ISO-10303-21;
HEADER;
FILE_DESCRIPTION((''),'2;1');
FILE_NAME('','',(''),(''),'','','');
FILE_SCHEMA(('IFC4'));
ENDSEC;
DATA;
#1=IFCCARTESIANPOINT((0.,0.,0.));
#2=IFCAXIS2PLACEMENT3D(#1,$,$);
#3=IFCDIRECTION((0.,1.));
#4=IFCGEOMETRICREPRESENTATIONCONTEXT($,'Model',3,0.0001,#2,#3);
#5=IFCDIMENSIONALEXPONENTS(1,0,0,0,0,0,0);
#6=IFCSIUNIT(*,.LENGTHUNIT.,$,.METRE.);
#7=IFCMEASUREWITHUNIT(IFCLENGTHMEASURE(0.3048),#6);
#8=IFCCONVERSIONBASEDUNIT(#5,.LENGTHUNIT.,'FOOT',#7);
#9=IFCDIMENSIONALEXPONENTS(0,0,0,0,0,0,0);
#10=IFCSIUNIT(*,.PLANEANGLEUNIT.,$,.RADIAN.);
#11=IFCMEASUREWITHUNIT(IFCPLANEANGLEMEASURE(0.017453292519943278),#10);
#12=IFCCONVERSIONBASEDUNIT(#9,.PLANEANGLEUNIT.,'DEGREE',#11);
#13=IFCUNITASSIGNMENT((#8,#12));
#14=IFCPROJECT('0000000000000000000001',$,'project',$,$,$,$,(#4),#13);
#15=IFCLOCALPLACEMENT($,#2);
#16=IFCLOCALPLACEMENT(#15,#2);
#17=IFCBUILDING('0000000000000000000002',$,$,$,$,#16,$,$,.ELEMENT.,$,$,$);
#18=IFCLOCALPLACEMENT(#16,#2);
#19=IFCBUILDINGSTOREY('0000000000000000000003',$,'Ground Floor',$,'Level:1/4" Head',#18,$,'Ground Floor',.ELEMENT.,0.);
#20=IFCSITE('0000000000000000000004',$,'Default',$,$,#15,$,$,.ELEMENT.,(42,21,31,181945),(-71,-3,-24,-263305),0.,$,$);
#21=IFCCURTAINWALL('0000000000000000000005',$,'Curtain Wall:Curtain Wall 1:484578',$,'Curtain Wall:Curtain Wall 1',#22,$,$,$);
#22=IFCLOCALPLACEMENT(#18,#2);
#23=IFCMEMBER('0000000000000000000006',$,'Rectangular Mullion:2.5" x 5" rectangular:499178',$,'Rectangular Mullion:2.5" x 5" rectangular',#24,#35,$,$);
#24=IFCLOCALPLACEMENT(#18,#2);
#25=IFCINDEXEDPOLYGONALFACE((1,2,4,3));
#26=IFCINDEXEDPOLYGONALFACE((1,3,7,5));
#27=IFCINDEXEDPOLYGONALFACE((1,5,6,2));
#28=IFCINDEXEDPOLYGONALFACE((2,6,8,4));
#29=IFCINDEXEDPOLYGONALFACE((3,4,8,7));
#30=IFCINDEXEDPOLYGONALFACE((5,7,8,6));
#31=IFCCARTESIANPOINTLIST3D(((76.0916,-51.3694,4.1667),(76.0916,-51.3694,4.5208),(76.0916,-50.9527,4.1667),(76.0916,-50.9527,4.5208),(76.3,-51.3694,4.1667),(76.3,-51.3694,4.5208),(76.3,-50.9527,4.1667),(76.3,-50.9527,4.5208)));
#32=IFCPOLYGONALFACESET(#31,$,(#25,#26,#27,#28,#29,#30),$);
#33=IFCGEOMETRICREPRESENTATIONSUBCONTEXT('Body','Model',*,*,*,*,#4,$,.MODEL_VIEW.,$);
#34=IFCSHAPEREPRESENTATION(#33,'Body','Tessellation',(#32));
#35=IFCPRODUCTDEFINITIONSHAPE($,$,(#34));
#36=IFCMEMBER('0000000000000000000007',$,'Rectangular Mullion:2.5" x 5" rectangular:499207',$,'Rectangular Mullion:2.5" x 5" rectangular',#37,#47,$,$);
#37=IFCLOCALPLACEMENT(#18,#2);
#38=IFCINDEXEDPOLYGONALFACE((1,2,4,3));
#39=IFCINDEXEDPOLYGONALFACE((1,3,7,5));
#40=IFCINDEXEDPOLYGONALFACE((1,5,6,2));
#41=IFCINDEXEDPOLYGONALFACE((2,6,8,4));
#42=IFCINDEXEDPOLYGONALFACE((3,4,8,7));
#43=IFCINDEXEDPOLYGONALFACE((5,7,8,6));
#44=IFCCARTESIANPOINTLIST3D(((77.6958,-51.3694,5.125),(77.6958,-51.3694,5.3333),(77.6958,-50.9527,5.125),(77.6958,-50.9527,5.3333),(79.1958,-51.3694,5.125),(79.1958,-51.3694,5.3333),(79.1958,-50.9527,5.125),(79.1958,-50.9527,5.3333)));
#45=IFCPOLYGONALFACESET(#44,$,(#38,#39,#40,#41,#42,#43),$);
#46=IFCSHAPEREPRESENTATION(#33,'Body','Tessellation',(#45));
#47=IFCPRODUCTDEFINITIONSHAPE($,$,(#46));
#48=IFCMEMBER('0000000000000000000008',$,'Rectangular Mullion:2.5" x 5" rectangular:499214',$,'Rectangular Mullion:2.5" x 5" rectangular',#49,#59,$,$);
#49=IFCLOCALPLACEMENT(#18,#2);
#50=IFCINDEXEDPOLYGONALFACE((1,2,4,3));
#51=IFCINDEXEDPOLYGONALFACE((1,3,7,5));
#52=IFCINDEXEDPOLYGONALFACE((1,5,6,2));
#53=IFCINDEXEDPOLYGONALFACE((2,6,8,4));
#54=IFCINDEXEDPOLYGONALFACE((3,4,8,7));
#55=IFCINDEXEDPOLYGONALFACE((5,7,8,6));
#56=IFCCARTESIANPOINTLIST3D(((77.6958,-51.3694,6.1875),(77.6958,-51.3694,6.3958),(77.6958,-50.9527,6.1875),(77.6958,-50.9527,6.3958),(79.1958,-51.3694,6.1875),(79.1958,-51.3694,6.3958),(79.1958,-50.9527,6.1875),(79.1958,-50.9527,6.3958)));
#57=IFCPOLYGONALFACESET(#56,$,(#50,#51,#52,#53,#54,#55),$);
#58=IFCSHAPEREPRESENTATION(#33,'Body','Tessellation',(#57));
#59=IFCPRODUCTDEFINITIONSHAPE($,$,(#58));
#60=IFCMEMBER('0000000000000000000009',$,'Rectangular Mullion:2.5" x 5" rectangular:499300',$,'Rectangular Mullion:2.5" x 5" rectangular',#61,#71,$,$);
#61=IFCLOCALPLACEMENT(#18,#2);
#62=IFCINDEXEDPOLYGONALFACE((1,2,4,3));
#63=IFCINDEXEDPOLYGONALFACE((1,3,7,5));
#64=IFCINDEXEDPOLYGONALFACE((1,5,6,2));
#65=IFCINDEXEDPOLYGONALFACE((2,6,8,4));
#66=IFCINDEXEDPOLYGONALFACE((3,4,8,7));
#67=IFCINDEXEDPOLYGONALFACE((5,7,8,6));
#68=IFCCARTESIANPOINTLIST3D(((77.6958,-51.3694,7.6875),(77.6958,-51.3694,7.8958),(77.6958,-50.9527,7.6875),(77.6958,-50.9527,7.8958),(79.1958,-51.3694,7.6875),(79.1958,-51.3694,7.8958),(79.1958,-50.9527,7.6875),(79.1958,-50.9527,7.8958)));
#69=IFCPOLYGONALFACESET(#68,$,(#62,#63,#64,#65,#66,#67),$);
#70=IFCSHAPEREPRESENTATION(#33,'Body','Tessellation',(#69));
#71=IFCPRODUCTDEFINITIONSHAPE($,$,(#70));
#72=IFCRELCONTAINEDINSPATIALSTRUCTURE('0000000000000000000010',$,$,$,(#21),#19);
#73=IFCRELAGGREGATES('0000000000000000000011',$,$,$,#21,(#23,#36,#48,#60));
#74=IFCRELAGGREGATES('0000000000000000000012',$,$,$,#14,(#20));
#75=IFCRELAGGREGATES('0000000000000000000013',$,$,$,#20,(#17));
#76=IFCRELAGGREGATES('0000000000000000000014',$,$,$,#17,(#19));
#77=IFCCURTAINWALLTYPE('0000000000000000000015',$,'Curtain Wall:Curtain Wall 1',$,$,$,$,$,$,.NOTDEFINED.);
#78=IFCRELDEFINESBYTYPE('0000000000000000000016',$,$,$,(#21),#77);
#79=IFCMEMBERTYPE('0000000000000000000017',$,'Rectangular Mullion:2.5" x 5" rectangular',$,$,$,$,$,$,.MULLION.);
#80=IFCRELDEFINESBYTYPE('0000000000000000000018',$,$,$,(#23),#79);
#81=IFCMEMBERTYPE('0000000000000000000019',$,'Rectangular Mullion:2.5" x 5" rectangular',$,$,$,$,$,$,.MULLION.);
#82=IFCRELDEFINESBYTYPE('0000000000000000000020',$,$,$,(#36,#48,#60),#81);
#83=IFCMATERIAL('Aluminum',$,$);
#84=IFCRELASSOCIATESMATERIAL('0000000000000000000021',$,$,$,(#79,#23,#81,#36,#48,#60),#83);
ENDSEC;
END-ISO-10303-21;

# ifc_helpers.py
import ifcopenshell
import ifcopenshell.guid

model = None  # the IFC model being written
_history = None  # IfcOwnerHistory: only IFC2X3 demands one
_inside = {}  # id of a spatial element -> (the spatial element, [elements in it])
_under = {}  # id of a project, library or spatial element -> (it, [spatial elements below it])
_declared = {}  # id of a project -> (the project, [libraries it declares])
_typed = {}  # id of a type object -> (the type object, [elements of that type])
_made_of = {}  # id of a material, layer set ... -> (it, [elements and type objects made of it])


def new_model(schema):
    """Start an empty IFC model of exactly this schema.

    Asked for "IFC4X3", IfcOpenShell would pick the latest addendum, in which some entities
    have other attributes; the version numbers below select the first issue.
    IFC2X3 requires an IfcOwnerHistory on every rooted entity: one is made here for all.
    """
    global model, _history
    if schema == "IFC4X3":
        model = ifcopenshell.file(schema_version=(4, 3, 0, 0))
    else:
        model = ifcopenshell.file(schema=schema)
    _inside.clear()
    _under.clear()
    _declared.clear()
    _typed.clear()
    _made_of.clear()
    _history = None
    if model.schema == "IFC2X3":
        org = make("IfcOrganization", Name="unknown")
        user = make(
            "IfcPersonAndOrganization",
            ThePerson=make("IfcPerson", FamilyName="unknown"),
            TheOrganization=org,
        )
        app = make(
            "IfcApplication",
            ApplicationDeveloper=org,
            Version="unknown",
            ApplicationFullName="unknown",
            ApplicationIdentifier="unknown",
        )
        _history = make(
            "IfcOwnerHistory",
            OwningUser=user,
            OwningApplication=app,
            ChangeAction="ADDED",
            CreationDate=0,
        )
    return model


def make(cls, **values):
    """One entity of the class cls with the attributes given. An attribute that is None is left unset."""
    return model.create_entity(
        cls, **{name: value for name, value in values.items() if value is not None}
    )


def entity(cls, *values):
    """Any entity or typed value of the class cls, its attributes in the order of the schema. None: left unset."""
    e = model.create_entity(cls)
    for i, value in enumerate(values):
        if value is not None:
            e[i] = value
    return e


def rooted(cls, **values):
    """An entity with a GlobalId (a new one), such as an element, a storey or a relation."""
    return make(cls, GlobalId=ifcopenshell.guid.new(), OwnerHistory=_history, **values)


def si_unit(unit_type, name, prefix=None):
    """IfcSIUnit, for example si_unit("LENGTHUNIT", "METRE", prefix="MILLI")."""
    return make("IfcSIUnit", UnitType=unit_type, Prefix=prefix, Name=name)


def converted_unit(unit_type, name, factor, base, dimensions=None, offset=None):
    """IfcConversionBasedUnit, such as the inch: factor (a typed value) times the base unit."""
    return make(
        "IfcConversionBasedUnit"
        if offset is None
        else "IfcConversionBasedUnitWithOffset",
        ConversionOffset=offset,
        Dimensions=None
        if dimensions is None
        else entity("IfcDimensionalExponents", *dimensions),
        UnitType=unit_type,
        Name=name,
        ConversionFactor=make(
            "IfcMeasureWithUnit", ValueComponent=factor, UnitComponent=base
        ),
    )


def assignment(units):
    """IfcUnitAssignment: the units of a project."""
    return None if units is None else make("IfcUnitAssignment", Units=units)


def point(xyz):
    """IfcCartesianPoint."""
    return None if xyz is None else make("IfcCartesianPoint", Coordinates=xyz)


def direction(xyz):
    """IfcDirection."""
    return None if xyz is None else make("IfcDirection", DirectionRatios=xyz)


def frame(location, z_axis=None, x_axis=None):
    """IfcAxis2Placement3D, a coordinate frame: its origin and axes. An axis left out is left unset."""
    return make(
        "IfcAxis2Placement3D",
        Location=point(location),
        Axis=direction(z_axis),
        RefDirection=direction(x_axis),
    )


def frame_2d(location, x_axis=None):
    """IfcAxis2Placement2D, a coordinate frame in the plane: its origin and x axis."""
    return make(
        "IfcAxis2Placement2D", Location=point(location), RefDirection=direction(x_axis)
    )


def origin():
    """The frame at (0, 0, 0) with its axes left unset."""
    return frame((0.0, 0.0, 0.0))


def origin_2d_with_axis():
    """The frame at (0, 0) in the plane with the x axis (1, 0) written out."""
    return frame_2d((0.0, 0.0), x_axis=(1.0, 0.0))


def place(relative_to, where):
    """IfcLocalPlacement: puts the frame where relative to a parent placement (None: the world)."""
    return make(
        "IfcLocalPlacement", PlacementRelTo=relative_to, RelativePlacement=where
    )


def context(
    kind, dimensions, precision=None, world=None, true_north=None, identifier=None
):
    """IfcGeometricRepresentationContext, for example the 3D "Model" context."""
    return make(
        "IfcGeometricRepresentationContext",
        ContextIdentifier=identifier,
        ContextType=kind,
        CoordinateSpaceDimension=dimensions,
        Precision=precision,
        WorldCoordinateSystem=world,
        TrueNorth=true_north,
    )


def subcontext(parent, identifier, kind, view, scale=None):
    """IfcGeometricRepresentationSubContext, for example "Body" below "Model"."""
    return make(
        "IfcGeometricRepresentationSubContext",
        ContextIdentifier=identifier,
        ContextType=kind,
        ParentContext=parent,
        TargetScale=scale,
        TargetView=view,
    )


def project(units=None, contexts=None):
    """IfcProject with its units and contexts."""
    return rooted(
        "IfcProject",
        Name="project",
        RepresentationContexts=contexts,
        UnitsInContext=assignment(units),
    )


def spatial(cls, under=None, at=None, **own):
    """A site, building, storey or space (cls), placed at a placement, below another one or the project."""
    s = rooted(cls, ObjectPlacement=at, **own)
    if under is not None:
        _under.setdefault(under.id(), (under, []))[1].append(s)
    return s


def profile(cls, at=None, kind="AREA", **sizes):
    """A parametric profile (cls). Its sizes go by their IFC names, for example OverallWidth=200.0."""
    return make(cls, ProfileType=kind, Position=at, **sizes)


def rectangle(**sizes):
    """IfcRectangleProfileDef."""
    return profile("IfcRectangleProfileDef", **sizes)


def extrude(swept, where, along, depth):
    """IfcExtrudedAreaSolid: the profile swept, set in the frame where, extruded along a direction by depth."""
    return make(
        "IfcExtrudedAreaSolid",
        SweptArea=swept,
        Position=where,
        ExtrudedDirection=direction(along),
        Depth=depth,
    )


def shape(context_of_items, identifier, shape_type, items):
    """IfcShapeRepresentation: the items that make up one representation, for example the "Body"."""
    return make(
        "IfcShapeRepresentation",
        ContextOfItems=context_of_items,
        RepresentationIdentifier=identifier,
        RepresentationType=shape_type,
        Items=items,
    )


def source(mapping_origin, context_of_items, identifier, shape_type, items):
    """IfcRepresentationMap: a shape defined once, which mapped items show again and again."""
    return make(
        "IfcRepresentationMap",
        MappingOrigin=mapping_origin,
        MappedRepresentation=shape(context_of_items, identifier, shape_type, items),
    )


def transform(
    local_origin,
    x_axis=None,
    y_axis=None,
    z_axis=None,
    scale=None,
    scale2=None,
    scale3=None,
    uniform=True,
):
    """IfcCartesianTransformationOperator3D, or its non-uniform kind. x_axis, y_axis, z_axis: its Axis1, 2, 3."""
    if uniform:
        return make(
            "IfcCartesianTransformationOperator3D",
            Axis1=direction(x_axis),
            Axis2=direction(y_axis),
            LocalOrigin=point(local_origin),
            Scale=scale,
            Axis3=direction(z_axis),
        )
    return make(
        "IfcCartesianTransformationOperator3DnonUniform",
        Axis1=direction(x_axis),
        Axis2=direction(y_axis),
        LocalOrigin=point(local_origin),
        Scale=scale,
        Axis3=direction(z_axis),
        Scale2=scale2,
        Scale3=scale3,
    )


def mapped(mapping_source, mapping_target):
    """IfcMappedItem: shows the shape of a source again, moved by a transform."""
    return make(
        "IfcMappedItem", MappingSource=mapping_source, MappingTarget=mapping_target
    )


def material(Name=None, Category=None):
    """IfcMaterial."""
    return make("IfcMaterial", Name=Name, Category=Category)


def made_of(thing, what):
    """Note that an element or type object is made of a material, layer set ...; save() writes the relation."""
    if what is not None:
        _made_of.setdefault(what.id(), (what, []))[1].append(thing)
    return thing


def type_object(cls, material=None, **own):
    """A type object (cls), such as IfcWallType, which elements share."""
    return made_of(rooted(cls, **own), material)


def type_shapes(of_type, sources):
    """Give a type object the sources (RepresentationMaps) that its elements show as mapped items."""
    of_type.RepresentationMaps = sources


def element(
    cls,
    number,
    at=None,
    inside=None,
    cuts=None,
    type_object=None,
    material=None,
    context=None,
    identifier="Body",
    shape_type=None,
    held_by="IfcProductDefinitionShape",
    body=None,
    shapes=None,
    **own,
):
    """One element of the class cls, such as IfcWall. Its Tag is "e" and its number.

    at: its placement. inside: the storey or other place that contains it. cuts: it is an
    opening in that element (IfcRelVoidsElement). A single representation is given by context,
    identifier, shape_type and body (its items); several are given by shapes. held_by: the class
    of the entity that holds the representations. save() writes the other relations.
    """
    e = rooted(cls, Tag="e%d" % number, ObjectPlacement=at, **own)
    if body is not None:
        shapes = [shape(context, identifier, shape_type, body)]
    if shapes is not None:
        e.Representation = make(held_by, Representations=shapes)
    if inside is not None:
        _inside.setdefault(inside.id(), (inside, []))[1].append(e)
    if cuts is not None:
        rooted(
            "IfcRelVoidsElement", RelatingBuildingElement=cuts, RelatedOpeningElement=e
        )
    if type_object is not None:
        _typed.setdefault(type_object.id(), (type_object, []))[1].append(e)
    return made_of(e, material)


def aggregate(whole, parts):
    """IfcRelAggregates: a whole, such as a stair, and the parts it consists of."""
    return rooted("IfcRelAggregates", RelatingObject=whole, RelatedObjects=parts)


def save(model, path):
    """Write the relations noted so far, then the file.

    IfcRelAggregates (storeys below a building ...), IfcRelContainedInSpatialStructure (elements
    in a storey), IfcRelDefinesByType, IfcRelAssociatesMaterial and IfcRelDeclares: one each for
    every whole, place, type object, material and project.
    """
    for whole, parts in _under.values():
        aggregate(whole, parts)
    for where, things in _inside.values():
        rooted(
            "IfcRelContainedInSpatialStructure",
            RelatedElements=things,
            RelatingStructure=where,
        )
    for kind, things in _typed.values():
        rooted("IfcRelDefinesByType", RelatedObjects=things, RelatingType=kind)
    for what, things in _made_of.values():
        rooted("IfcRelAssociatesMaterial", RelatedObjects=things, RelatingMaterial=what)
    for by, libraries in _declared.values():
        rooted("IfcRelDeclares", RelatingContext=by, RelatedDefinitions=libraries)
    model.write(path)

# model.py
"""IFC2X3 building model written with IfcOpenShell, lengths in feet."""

from ifc_helpers import new_model, entity, si_unit, converted_unit, direction, frame, origin, origin_2d_with_axis, place, context, subcontext, project, spatial, rectangle, extrude, source, transform, mapped, material, type_object, type_shapes, element, aggregate, save


model = new_model("IFC2X3")

# Units and contexts
model_context = context("Model", 3, precision=0.0001, world=origin(), true_north=direction((0.0, 1.0)))
body_context = subcontext(model_context, "Body", "Model", "MODEL_VIEW")
ifc_project = project(units=[converted_unit("LENGTHUNIT", "FOOT", entity("IfcLengthMeasure", 0.3048), si_unit("LENGTHUNIT", "METRE"), dimensions=[1, 0, 0, 0, 0, 0, 0]), converted_unit("PLANEANGLEUNIT", "DEGREE", entity("IfcPlaneAngleMeasure", 0.017453292519943278), si_unit("PLANEANGLEUNIT", "RADIAN"), dimensions=[0, 0, 0, 0, 0, 0, 0])], contexts=[model_context])

# Site, building, storey
site_placement = place(None, origin())
site = spatial("IfcSite", under=ifc_project, at=site_placement, Name="Default", CompositionType="ELEMENT", RefLatitude=(42, 21, 31, 181945), RefLongitude=(-71, -3, -24, -263305), RefElevation=0.0)
building_placement = place(site_placement, origin())
building = spatial("IfcBuilding", under=site, at=building_placement, CompositionType="ELEMENT")
storey_placement = place(building_placement, origin())
storey = spatial("IfcBuildingStorey", under=building, at=storey_placement, Name="Ground Floor", ObjectType="Level:1/4\" Head", LongName="Ground Floor", CompositionType="ELEMENT", Elevation=0.0)

# Curtain wall, members
curtain_wall_type = type_object("IfcCurtainWallType", Name="Curtain Wall:Curtain Wall 1", PredefinedType="NOTDEFINED")
curtain_wall_placement = place(storey_placement, origin())
curtain_wall = element("IfcCurtainWall", 1, at=curtain_wall_placement, inside=storey, type_object=curtain_wall_type, Name="Curtain Wall:Curtain Wall 1:484578", ObjectType="Curtain Wall:Curtain Wall 1")
ifc_material_1 = material(Name="Aluminum")
member_type_1 = type_object("IfcMemberType", Name="Rectangular Mullion:2.5\" x 5\" rectangular", PredefinedType="MULLION", material=ifc_material_1)
shared_shape_1 = source(origin(), body_context, "Body", "SweptSolid", [
    extrude(rectangle(XDim=0.2083, YDim=0.4167, at=origin_2d_with_axis()), frame((0.0, 0.0, -0.3542), z_axis=(0.0, 0.0, 1.0), x_axis=(-1.0, 0.0, 0.0)), (0.0, 0.0, 1.0), 0.3542),
])
type_shapes(member_type_1, [shared_shape_1])
member_1_placement = place(curtain_wall_placement, frame((76.1958, -51.161, 4.1667), z_axis=(0.0, 0.0, -1.0), x_axis=(1.0, 0.0, 0.0)))
member_1 = element("IfcMember", 2, at=member_1_placement, type_object=member_type_1, material=ifc_material_1, Name="Rectangular Mullion:2.5\" x 5\" rectangular:499178", ObjectType="Rectangular Mullion:2.5\" x 5\" rectangular", context=body_context, shape_type="MappedRepresentation", body=[
    mapped(shared_shape_1, transform((0.0, 0.0, 0.0), scale=1.0)),
])
member_type_2 = type_object("IfcMemberType", Name="Rectangular Mullion:2.5\" x 5\" rectangular", PredefinedType="MULLION", material=ifc_material_1)
shared_shape_2 = source(origin(), body_context, "Body", "SweptSolid", [
    extrude(rectangle(XDim=0.2083, YDim=0.4167, at=origin_2d_with_axis()), frame((0.0, 0.0, -1.5), z_axis=(0.0, 0.0, 1.0), x_axis=(-1.0, 0.0, 0.0)), (0.0, 0.0, 1.0), 1.5),
])
type_shapes(member_type_2, [shared_shape_2])
member_2_placement = place(curtain_wall_placement, frame((79.1958, -51.161, 5.2292), z_axis=(1.0, 0.0, 0.0), x_axis=(0.0, 0.0, 1.0)))
member_2 = element("IfcMember", 3, at=member_2_placement, type_object=member_type_2, material=ifc_material_1, Name="Rectangular Mullion:2.5\" x 5\" rectangular:499207", ObjectType="Rectangular Mullion:2.5\" x 5\" rectangular", context=body_context, shape_type="MappedRepresentation", body=[
    mapped(shared_shape_2, transform((0.0, 0.0, 0.0), scale=1.0)),
])
member_3_placement = place(curtain_wall_placement, frame((79.1958, -51.161, 6.2917), z_axis=(1.0, 0.0, 0.0), x_axis=(0.0, 0.0, 1.0)))
member_3 = element("IfcMember", 4, at=member_3_placement, type_object=member_type_2, material=ifc_material_1, Name="Rectangular Mullion:2.5\" x 5\" rectangular:499214", ObjectType="Rectangular Mullion:2.5\" x 5\" rectangular", context=body_context, shape_type="MappedRepresentation", body=[
    mapped(shared_shape_2, transform((0.0, 0.0, 0.0), scale=1.0)),
])
member_4_placement = place(curtain_wall_placement, frame((79.1958, -51.161, 7.7917), z_axis=(1.0, 0.0, 0.0), x_axis=(0.0, 0.0, 1.0)))
member_4 = element("IfcMember", 5, at=member_4_placement, type_object=member_type_2, material=ifc_material_1, Name="Rectangular Mullion:2.5\" x 5\" rectangular:499300", ObjectType="Rectangular Mullion:2.5\" x 5\" rectangular", context=body_context, shape_type="MappedRepresentation", body=[
    mapped(shared_shape_2, transform((0.0, 0.0, 0.0), scale=1.0)),
])
aggregate(curtain_wall, [member_1, member_2, member_3, member_4])

save(model, "model.ifc")
